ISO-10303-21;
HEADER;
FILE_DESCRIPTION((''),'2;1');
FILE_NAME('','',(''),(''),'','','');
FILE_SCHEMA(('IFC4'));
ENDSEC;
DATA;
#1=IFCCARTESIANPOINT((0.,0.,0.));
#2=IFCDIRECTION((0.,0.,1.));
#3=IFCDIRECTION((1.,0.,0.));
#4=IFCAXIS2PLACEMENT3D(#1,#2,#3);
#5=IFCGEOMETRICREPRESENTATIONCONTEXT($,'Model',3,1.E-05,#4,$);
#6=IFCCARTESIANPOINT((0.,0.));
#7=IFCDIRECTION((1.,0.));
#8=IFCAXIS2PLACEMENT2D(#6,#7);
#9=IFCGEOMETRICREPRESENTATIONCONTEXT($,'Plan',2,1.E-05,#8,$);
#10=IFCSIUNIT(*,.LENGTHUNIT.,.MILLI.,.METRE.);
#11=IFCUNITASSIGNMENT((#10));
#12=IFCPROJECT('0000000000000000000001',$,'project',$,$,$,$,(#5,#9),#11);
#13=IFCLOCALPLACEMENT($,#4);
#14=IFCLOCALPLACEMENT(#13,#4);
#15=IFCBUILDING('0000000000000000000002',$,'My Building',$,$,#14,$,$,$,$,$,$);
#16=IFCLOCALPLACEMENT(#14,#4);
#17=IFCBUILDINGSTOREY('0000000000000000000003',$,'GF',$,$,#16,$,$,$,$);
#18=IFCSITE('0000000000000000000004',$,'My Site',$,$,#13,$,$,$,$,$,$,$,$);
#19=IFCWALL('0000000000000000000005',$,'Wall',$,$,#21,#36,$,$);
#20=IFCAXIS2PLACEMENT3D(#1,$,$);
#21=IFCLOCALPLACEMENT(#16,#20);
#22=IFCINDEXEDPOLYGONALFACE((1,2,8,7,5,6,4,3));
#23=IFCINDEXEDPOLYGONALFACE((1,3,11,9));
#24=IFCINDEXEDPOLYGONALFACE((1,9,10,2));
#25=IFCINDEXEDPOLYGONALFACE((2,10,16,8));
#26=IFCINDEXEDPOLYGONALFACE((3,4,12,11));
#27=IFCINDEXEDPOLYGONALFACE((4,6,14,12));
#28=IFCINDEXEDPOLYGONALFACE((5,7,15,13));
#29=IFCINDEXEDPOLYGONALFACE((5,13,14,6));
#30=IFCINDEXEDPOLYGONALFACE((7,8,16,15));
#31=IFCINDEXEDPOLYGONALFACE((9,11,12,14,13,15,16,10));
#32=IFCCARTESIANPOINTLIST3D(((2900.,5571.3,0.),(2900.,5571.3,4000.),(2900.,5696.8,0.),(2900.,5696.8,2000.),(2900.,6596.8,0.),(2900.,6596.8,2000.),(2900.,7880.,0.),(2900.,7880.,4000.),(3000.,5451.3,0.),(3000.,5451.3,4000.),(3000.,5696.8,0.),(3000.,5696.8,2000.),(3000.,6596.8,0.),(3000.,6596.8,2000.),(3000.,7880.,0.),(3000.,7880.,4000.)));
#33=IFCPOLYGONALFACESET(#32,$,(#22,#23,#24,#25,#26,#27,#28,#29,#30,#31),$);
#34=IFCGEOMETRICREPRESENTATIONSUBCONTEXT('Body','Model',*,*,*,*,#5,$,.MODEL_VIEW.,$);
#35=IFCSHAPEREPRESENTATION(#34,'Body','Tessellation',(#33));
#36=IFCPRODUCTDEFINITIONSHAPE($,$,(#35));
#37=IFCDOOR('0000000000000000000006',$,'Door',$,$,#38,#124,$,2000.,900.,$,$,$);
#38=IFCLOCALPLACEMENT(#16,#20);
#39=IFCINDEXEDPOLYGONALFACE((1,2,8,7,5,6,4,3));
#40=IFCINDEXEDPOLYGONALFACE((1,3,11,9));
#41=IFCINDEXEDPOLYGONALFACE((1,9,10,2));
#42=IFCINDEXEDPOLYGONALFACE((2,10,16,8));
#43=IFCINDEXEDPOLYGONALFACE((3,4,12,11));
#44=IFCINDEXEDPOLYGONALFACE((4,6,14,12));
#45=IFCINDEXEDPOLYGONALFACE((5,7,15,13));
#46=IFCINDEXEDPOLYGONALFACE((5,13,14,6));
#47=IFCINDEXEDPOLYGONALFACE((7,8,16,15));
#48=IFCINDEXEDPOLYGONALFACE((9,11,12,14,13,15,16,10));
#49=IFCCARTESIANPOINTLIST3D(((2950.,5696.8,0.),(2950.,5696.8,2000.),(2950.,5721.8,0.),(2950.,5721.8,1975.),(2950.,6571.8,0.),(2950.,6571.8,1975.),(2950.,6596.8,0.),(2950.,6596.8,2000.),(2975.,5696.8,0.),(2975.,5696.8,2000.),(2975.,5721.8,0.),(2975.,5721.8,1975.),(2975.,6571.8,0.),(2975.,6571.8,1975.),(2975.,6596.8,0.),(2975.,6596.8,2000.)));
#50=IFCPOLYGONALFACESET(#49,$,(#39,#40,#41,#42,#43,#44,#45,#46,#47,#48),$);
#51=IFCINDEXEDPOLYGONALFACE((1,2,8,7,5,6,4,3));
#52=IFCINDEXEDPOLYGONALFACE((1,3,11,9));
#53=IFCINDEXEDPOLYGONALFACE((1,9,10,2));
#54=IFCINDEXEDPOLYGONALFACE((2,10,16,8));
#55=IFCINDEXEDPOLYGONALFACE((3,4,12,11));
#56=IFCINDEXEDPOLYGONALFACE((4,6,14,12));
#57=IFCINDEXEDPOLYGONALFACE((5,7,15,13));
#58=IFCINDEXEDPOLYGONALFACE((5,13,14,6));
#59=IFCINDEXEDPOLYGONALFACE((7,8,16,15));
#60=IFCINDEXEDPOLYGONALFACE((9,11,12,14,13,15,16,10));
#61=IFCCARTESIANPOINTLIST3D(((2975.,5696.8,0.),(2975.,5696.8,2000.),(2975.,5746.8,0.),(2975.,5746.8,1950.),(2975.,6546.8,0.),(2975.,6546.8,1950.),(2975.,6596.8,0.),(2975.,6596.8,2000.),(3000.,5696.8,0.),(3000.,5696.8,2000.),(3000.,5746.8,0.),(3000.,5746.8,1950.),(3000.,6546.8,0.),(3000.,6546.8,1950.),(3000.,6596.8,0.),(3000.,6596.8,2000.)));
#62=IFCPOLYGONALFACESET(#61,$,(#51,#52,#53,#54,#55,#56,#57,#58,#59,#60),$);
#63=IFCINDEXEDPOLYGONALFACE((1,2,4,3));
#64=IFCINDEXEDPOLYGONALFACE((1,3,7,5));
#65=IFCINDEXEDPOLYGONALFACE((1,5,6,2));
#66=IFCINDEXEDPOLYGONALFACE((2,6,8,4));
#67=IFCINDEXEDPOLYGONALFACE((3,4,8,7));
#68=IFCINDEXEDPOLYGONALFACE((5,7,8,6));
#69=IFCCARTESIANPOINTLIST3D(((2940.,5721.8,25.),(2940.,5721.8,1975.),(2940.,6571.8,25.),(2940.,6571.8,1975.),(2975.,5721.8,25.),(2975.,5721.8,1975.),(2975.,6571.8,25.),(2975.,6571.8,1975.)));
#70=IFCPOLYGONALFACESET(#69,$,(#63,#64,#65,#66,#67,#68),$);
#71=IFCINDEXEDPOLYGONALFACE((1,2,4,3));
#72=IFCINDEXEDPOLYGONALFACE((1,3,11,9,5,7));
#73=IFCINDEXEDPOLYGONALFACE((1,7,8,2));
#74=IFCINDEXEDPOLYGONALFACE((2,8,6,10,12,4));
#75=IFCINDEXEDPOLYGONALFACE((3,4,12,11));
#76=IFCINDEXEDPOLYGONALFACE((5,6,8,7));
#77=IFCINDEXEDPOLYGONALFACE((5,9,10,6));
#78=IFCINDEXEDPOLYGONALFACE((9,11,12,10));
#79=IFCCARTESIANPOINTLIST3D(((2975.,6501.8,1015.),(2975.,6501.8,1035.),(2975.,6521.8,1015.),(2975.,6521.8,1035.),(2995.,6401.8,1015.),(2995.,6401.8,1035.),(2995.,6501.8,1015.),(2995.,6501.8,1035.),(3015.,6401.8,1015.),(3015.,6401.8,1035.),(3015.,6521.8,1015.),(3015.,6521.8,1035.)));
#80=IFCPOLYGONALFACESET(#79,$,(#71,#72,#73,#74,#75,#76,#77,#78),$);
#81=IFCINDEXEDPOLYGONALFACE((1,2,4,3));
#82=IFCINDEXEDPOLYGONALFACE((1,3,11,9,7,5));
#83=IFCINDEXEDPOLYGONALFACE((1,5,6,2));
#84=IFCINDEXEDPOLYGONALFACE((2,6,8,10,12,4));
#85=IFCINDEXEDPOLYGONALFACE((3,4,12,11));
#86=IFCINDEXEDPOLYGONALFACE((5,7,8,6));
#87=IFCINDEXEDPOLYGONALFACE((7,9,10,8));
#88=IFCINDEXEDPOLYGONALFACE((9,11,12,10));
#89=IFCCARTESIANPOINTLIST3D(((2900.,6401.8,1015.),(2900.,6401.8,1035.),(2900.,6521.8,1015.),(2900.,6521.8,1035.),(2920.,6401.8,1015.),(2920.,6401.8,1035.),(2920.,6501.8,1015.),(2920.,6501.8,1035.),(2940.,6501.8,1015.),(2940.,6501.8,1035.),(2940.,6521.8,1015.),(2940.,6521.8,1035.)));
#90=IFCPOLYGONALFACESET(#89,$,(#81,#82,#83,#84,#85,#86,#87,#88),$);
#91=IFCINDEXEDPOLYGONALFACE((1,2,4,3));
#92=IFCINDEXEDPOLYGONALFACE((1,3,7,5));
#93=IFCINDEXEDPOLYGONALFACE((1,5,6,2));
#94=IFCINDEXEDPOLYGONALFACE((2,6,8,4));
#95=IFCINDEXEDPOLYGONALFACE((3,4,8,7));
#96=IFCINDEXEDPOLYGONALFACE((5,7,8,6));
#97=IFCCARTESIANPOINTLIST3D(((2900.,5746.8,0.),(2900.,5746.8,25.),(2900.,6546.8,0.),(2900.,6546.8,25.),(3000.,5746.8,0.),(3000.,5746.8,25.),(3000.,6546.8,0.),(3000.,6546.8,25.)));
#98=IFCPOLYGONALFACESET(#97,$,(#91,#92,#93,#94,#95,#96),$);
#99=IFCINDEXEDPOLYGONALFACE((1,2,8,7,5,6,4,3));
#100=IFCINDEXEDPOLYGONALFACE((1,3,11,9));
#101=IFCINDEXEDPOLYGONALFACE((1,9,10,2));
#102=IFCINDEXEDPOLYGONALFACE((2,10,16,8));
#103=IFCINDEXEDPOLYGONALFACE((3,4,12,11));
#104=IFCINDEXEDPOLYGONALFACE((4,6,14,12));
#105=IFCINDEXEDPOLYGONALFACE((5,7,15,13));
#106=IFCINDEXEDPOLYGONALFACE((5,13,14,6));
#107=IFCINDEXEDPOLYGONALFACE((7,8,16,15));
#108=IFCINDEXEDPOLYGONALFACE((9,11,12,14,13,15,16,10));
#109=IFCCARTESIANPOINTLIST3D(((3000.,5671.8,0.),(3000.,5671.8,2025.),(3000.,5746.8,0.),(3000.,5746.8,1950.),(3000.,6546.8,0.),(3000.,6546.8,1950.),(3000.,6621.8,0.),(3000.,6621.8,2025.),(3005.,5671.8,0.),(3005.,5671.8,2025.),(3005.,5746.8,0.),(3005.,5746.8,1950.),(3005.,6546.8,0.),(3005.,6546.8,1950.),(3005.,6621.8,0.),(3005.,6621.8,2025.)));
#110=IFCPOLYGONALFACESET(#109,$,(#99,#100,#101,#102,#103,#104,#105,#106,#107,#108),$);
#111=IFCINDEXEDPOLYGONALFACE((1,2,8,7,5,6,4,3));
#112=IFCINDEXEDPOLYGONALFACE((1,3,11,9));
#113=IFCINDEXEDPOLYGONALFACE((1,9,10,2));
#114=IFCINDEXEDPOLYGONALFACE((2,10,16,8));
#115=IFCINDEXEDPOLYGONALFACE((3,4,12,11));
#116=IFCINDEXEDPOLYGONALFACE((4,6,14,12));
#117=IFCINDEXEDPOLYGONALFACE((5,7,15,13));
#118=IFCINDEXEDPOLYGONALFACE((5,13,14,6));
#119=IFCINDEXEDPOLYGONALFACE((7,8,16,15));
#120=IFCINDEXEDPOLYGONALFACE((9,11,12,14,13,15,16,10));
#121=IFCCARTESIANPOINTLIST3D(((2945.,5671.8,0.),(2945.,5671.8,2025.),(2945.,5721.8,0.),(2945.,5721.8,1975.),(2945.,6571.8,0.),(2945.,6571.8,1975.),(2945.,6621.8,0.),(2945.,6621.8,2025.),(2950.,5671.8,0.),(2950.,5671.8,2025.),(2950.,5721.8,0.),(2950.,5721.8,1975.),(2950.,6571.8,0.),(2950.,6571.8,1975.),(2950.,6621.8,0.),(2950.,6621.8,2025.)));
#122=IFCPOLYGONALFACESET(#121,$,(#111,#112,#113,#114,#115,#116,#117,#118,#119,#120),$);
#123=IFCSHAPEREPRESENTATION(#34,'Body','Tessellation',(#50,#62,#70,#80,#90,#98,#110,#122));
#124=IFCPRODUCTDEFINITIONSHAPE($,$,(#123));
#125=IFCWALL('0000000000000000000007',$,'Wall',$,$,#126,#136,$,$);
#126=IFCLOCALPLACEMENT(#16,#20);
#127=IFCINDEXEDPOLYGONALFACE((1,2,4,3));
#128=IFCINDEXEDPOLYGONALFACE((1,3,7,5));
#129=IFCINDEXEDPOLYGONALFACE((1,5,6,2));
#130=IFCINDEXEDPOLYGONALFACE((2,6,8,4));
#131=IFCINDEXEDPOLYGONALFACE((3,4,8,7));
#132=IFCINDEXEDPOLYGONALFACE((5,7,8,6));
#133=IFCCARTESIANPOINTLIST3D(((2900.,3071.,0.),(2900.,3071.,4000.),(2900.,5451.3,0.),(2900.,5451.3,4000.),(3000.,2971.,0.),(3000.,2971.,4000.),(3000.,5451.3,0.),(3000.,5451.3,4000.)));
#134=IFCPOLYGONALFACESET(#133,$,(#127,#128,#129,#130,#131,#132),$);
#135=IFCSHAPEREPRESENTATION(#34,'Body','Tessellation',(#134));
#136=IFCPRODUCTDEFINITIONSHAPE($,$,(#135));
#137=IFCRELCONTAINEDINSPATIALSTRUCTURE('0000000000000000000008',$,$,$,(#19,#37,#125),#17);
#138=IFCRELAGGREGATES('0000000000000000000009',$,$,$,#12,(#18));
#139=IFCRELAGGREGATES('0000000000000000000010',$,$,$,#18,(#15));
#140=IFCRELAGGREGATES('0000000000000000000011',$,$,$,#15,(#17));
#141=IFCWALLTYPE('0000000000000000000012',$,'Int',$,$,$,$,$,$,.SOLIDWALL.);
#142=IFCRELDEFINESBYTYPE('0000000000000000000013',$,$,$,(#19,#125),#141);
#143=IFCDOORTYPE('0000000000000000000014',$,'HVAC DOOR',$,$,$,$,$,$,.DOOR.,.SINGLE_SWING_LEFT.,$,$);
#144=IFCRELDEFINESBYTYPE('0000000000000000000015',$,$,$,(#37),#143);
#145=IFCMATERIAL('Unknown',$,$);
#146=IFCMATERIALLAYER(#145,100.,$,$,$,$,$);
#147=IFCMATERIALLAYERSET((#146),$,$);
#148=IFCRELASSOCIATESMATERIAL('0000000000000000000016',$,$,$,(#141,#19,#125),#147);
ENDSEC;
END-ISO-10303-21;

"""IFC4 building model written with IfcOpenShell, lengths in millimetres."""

from ifc_helpers import new_model, entity, si_unit, frame, origin_with_axes, origin_2d_with_axis, place, context, subcontext, project, spatial, line, indexed_curve, outline, extrude, shape, source, transform, mapped, material, layer, layer_set, layer_usage, type_object, type_shapes, element, fill, save


model = new_model("IFC4")

# Units and contexts
model_context = context("Model", 3, precision=1e-05, world=origin_with_axes())
plan_context = context("Plan", 2, precision=1e-05, world=origin_2d_with_axis())
body_context_1 = subcontext(model_context, "Body", "Model", "MODEL_VIEW")
body_context_2 = subcontext(plan_context, "Body", "Plan", "PLAN_VIEW")
ifc_project = project(units=[si_unit("LENGTHUNIT", "METRE", prefix="MILLI")], contexts=[model_context, plan_context])

# Site, building, storey
site_placement = place(None, origin_with_axes())
site = spatial("IfcSite", under=ifc_project, at=site_placement, Name="My Site")
building_placement = place(site_placement, origin_with_axes())
building = spatial("IfcBuilding", under=site, at=building_placement, Name="My Building")
storey_placement = place(building_placement, origin_with_axes())
storey = spatial("IfcBuildingStorey", under=building, at=storey_placement, Name="GF")

# Shared definitions
ifc_material = material(Name="Unknown")

# Wall, opening, door
ifc_layer_1 = layer(ifc_material, 100.0)
ifc_layer_set_1 = layer_set([ifc_layer_1])
ifc_layer_usage_1 = layer_usage(ifc_layer_set_1, "AXIS2", "POSITIVE", 0.0)
wall_type_1 = type_object("IfcWallType", Name="Int", PredefinedType="SOLIDWALL", material=ifc_layer_set_1)
wall_1_placement = place(storey_placement, frame((3000.0, 5571.3, 0.0), z_axis=(0.0, 0.0, 1.0), x_axis=(0.0, 1.0, 0.0)))
wall_1 = element("IfcWall", 1, at=wall_1_placement, inside=storey, type_object=wall_type_1, material=ifc_layer_usage_1, Name="Wall", context=body_context_1, shape_type="SweptSolid", body=[
    extrude(outline(indexed_curve([(-120.0, 0.0), (0.0, 100.0), (2308.7, 100.0), (2308.7, 0.0)], segments=[line(1, 2, 3, 4, 1)])), origin_with_axes(), (0.0, 0.0, 1.0), 4000.0),
])
shared_shape_1 = source(origin_with_axes(), body_context_1, "Body", "SweptSolid", [
    extrude(outline(indexed_curve([(0.0, 0.0), (900.0, 0.0), (900.0, 2000.0), (0.0, 2000.0)], segments=[line(1, 2, 3, 4, 1)])), frame((0.0, -600.0, 0.0), z_axis=(0.0, -1.0, 0.0), x_axis=(1.0, 0.0, 0.0)), (0.0, 0.0, -1.0), 1200.0),
])
opening_1_placement = place(wall_1_placement, frame((125.6, 0.0, 0.0), z_axis=(0.0, 0.0, 1.0), x_axis=(1.0, 0.0, 0.0)))
opening_1 = element("IfcOpeningElement", 2, at=opening_1_placement, cuts=wall_1, PredefinedType="OPENING", context=body_context_1, shape_type="MappedRepresentation", body=[
    mapped(shared_shape_1, transform((0.0, 0.0, 0.0), x_axis=(1.0, 0.0, 0.0), y_axis=(0.0, 1.0, 0.0), z_axis=(0.0, 0.0, 1.0), scale=1.0)),
])
door_type_1 = type_object("IfcDoorType", Name="HVAC DOOR", OperationType="SINGLE_SWING_LEFT", PredefinedType="DOOR")
shared_shape_2 = source(origin_with_axes(), body_context_1, "Body", "SweptSolid", [
    extrude(outline(indexed_curve([(0.0, 0.0), (0.0, 2000.0), (900.0, 2000.0), (900.0, 0.0), (875.0, 0.0), (875.0, 1975.0), (25.0, 1975.0), (25.0, 0.0)], segments=[line(1, 2, 3, 4, 5, 6, 7, 8, 1)])), frame((0.0, 25.0, 0.0), z_axis=(0.0, -1.0, 0.0), x_axis=(1.0, 0.0, 0.0)), (0.0, 0.0, -1.0), 25.0),
    extrude(outline(indexed_curve([(0.0, 0.0), (0.0, 2000.0), (900.0, 2000.0), (900.0, 0.0), (850.0, 0.0), (850.0, 1950.0), (50.0, 1950.0), (50.0, 0.0)], segments=[line(1, 2, 3, 4, 5, 6, 7, 8, 1)])), frame((0.0, 0.0, 0.0), z_axis=(0.0, -1.0, 0.0), x_axis=(1.0, 0.0, 0.0)), (0.0, 0.0, -1.0), 25.0),
    extrude(outline(indexed_curve([(0.0, 0.0), (850.0, 0.0), (850.0, 35.0), (0.0, 35.0)], segments=[line(1, 2, 3, 4, 1)])), frame((25.0, 25.0, 25.0), z_axis=(0.0, 0.0, 1.0), x_axis=(1.0, 0.0, 0.0)), (0.0, 0.0, 1.0), 1950.0),
    extrude(outline(indexed_curve([(0.0, 0.0), (0.0, -40.0), (-120.0, -40.0), (-120.0, -20.0), (-20.0, -20.0), (-20.0, 0.0)], segments=[line(1, 2, 3, 4, 5, 6, 1)])), frame((825.0, 25.0, 1015.0), z_axis=(0.0, 0.0, 1.0), x_axis=(1.0, 0.0, 0.0)), (0.0, 0.0, 1.0), 20.0),
    extrude(outline(indexed_curve([(0.0, 0.0), (0.0, 40.0), (-120.0, 40.0), (-120.0, 20.0), (-20.0, 20.0), (-20.0, 0.0)], segments=[line(1, 2, 3, 4, 5, 6, 1)])), frame((825.0, 60.0, 1015.0), z_axis=(0.0, 0.0, 1.0), x_axis=(1.0, 0.0, 0.0)), (0.0, 0.0, 1.0), 20.0),
    extrude(outline(indexed_curve([(0.0, 0.0), (800.0, 0.0), (800.0, 100.0), (0.0, 100.0)], segments=[line(1, 2, 3, 4, 1)])), frame((50.0, 0.0, 0.0), z_axis=(0.0, 0.0, 1.0), x_axis=(1.0, 0.0, 0.0)), (0.0, 0.0, 1.0), 25.0),
    extrude(outline(indexed_curve([(0.0, 0.0), (0.0, 2025.0), (950.0, 2025.0), (950.0, 0.0), (875.0, 0.0), (875.0, 1950.0), (75.0, 1950.0), (75.0, 0.0)], segments=[line(1, 2, 3, 4, 5, 6, 7, 8, 1)])), frame((-25.0, -5.0, 0.0), z_axis=(0.0, -1.0, 0.0), x_axis=(1.0, 0.0, 0.0)), (0.0, 0.0, -1.0), 5.0),
    extrude(outline(indexed_curve([(0.0, 0.0), (0.0, 2025.0), (950.0, 2025.0), (950.0, 0.0), (900.0, 0.0), (900.0, 1975.0), (50.0, 1975.0), (50.0, 0.0)], segments=[line(1, 2, 3, 4, 5, 6, 7, 8, 1)])), frame((-25.0, 50.0, 0.0), z_axis=(0.0, -1.0, 0.0), x_axis=(1.0, 0.0, 0.0)), (0.0, 0.0, -1.0), 5.0),
])
shared_shape_3 = source(origin_with_axes(), body_context_2, "Body", "Curve2D", [
    entity("IfcIndexedPolyCurve", entity("IfcCartesianPointList2D", [[0.0, 0.0], [0.0, 50.0], [25.0, 50.0], [25.0, 25.0], [50.0, 25.0], [50.0, 0.0]]), [entity("IfcLineIndex", [1, 2, 3, 4, 5, 6, 1])]),
    entity("IfcIndexedPolyCurve", entity("IfcCartesianPointList2D", [[900.0, 0.0], [900.0, 50.0], [875.0, 50.0], [875.0, 25.0], [850.0, 25.0], [850.0, 0.0]]), [entity("IfcLineIndex", [1, 2, 3, 4, 5, 6, 1])]),
    entity("IfcTrimmedCurve", entity("IfcEllipse", entity("IfcAxis2Placement2D", entity("IfcCartesianPoint", [60.0, 50.0]), entity("IfcDirection", [1.0, 0.0])), 815.0, 850.0), [entity("IfcCartesianPoint", [875.0, 50.0])], [entity("IfcCartesianPoint", [60.0, 900.0])], True, "CARTESIAN"),
    entity("IfcIndexedPolyCurve", entity("IfcCartesianPointList2D", [[25.0, 50.0], [60.0, 50.0], [60.0, 900.0], [25.0, 900.0]]), [entity("IfcLineIndex", [1, 2, 3, 4, 1])]),
])
type_shapes(door_type_1, [shared_shape_2, shared_shape_3])
door_1_placement = place(opening_1_placement, frame((0.0, 0.0, 0.0), z_axis=(0.0, 0.0, 1.0), x_axis=(1.0, 0.0, 0.0)))
door_1 = element("IfcDoor", 3, at=door_1_placement, inside=storey, type_object=door_type_1, Name="Door", OverallHeight=2000.0, OverallWidth=900.0, shapes=[
    shape(body_context_1, "Body", "MappedRepresentation", [mapped(shared_shape_2, transform((0.0, 0.0, 0.0), x_axis=(1.0, 0.0, 0.0), y_axis=(0.0, 1.0, 0.0), z_axis=(0.0, 0.0, 1.0), scale=1.0))]),
    shape(body_context_2, "Body", "MappedRepresentation", [mapped(shared_shape_3, transform((0.0, 0.0, 0.0), x_axis=(1.0, 0.0, 0.0), y_axis=(0.0, 1.0, 0.0), z_axis=(0.0, 0.0, 1.0), scale=1.0))]),
])
fill(opening_1, door_1)

# Wall
ifc_layer_usage_2 = layer_usage(ifc_layer_set_1, "AXIS2", "POSITIVE", 0.0)
wall_2_placement = place(storey_placement, frame((2900.0, 5451.3, 0.0), z_axis=(0.0, 0.0, 1.0), x_axis=(0.0, -1.0, 0.0)))
element("IfcWall", 4, at=wall_2_placement, inside=storey, type_object=wall_type_1, material=ifc_layer_usage_2, Name="Wall", context=body_context_1, shape_type="SweptSolid", body=[
    extrude(outline(indexed_curve([(0.0, 0.0), (0.0, 100.0), (2480.3, 100.0), (2380.3, 0.0)], segments=[line(1, 2, 3, 4, 1)])), origin_with_axes(), (0.0, 0.0, 1.0), 4000.0),
])

save(model, "model.ifc")
